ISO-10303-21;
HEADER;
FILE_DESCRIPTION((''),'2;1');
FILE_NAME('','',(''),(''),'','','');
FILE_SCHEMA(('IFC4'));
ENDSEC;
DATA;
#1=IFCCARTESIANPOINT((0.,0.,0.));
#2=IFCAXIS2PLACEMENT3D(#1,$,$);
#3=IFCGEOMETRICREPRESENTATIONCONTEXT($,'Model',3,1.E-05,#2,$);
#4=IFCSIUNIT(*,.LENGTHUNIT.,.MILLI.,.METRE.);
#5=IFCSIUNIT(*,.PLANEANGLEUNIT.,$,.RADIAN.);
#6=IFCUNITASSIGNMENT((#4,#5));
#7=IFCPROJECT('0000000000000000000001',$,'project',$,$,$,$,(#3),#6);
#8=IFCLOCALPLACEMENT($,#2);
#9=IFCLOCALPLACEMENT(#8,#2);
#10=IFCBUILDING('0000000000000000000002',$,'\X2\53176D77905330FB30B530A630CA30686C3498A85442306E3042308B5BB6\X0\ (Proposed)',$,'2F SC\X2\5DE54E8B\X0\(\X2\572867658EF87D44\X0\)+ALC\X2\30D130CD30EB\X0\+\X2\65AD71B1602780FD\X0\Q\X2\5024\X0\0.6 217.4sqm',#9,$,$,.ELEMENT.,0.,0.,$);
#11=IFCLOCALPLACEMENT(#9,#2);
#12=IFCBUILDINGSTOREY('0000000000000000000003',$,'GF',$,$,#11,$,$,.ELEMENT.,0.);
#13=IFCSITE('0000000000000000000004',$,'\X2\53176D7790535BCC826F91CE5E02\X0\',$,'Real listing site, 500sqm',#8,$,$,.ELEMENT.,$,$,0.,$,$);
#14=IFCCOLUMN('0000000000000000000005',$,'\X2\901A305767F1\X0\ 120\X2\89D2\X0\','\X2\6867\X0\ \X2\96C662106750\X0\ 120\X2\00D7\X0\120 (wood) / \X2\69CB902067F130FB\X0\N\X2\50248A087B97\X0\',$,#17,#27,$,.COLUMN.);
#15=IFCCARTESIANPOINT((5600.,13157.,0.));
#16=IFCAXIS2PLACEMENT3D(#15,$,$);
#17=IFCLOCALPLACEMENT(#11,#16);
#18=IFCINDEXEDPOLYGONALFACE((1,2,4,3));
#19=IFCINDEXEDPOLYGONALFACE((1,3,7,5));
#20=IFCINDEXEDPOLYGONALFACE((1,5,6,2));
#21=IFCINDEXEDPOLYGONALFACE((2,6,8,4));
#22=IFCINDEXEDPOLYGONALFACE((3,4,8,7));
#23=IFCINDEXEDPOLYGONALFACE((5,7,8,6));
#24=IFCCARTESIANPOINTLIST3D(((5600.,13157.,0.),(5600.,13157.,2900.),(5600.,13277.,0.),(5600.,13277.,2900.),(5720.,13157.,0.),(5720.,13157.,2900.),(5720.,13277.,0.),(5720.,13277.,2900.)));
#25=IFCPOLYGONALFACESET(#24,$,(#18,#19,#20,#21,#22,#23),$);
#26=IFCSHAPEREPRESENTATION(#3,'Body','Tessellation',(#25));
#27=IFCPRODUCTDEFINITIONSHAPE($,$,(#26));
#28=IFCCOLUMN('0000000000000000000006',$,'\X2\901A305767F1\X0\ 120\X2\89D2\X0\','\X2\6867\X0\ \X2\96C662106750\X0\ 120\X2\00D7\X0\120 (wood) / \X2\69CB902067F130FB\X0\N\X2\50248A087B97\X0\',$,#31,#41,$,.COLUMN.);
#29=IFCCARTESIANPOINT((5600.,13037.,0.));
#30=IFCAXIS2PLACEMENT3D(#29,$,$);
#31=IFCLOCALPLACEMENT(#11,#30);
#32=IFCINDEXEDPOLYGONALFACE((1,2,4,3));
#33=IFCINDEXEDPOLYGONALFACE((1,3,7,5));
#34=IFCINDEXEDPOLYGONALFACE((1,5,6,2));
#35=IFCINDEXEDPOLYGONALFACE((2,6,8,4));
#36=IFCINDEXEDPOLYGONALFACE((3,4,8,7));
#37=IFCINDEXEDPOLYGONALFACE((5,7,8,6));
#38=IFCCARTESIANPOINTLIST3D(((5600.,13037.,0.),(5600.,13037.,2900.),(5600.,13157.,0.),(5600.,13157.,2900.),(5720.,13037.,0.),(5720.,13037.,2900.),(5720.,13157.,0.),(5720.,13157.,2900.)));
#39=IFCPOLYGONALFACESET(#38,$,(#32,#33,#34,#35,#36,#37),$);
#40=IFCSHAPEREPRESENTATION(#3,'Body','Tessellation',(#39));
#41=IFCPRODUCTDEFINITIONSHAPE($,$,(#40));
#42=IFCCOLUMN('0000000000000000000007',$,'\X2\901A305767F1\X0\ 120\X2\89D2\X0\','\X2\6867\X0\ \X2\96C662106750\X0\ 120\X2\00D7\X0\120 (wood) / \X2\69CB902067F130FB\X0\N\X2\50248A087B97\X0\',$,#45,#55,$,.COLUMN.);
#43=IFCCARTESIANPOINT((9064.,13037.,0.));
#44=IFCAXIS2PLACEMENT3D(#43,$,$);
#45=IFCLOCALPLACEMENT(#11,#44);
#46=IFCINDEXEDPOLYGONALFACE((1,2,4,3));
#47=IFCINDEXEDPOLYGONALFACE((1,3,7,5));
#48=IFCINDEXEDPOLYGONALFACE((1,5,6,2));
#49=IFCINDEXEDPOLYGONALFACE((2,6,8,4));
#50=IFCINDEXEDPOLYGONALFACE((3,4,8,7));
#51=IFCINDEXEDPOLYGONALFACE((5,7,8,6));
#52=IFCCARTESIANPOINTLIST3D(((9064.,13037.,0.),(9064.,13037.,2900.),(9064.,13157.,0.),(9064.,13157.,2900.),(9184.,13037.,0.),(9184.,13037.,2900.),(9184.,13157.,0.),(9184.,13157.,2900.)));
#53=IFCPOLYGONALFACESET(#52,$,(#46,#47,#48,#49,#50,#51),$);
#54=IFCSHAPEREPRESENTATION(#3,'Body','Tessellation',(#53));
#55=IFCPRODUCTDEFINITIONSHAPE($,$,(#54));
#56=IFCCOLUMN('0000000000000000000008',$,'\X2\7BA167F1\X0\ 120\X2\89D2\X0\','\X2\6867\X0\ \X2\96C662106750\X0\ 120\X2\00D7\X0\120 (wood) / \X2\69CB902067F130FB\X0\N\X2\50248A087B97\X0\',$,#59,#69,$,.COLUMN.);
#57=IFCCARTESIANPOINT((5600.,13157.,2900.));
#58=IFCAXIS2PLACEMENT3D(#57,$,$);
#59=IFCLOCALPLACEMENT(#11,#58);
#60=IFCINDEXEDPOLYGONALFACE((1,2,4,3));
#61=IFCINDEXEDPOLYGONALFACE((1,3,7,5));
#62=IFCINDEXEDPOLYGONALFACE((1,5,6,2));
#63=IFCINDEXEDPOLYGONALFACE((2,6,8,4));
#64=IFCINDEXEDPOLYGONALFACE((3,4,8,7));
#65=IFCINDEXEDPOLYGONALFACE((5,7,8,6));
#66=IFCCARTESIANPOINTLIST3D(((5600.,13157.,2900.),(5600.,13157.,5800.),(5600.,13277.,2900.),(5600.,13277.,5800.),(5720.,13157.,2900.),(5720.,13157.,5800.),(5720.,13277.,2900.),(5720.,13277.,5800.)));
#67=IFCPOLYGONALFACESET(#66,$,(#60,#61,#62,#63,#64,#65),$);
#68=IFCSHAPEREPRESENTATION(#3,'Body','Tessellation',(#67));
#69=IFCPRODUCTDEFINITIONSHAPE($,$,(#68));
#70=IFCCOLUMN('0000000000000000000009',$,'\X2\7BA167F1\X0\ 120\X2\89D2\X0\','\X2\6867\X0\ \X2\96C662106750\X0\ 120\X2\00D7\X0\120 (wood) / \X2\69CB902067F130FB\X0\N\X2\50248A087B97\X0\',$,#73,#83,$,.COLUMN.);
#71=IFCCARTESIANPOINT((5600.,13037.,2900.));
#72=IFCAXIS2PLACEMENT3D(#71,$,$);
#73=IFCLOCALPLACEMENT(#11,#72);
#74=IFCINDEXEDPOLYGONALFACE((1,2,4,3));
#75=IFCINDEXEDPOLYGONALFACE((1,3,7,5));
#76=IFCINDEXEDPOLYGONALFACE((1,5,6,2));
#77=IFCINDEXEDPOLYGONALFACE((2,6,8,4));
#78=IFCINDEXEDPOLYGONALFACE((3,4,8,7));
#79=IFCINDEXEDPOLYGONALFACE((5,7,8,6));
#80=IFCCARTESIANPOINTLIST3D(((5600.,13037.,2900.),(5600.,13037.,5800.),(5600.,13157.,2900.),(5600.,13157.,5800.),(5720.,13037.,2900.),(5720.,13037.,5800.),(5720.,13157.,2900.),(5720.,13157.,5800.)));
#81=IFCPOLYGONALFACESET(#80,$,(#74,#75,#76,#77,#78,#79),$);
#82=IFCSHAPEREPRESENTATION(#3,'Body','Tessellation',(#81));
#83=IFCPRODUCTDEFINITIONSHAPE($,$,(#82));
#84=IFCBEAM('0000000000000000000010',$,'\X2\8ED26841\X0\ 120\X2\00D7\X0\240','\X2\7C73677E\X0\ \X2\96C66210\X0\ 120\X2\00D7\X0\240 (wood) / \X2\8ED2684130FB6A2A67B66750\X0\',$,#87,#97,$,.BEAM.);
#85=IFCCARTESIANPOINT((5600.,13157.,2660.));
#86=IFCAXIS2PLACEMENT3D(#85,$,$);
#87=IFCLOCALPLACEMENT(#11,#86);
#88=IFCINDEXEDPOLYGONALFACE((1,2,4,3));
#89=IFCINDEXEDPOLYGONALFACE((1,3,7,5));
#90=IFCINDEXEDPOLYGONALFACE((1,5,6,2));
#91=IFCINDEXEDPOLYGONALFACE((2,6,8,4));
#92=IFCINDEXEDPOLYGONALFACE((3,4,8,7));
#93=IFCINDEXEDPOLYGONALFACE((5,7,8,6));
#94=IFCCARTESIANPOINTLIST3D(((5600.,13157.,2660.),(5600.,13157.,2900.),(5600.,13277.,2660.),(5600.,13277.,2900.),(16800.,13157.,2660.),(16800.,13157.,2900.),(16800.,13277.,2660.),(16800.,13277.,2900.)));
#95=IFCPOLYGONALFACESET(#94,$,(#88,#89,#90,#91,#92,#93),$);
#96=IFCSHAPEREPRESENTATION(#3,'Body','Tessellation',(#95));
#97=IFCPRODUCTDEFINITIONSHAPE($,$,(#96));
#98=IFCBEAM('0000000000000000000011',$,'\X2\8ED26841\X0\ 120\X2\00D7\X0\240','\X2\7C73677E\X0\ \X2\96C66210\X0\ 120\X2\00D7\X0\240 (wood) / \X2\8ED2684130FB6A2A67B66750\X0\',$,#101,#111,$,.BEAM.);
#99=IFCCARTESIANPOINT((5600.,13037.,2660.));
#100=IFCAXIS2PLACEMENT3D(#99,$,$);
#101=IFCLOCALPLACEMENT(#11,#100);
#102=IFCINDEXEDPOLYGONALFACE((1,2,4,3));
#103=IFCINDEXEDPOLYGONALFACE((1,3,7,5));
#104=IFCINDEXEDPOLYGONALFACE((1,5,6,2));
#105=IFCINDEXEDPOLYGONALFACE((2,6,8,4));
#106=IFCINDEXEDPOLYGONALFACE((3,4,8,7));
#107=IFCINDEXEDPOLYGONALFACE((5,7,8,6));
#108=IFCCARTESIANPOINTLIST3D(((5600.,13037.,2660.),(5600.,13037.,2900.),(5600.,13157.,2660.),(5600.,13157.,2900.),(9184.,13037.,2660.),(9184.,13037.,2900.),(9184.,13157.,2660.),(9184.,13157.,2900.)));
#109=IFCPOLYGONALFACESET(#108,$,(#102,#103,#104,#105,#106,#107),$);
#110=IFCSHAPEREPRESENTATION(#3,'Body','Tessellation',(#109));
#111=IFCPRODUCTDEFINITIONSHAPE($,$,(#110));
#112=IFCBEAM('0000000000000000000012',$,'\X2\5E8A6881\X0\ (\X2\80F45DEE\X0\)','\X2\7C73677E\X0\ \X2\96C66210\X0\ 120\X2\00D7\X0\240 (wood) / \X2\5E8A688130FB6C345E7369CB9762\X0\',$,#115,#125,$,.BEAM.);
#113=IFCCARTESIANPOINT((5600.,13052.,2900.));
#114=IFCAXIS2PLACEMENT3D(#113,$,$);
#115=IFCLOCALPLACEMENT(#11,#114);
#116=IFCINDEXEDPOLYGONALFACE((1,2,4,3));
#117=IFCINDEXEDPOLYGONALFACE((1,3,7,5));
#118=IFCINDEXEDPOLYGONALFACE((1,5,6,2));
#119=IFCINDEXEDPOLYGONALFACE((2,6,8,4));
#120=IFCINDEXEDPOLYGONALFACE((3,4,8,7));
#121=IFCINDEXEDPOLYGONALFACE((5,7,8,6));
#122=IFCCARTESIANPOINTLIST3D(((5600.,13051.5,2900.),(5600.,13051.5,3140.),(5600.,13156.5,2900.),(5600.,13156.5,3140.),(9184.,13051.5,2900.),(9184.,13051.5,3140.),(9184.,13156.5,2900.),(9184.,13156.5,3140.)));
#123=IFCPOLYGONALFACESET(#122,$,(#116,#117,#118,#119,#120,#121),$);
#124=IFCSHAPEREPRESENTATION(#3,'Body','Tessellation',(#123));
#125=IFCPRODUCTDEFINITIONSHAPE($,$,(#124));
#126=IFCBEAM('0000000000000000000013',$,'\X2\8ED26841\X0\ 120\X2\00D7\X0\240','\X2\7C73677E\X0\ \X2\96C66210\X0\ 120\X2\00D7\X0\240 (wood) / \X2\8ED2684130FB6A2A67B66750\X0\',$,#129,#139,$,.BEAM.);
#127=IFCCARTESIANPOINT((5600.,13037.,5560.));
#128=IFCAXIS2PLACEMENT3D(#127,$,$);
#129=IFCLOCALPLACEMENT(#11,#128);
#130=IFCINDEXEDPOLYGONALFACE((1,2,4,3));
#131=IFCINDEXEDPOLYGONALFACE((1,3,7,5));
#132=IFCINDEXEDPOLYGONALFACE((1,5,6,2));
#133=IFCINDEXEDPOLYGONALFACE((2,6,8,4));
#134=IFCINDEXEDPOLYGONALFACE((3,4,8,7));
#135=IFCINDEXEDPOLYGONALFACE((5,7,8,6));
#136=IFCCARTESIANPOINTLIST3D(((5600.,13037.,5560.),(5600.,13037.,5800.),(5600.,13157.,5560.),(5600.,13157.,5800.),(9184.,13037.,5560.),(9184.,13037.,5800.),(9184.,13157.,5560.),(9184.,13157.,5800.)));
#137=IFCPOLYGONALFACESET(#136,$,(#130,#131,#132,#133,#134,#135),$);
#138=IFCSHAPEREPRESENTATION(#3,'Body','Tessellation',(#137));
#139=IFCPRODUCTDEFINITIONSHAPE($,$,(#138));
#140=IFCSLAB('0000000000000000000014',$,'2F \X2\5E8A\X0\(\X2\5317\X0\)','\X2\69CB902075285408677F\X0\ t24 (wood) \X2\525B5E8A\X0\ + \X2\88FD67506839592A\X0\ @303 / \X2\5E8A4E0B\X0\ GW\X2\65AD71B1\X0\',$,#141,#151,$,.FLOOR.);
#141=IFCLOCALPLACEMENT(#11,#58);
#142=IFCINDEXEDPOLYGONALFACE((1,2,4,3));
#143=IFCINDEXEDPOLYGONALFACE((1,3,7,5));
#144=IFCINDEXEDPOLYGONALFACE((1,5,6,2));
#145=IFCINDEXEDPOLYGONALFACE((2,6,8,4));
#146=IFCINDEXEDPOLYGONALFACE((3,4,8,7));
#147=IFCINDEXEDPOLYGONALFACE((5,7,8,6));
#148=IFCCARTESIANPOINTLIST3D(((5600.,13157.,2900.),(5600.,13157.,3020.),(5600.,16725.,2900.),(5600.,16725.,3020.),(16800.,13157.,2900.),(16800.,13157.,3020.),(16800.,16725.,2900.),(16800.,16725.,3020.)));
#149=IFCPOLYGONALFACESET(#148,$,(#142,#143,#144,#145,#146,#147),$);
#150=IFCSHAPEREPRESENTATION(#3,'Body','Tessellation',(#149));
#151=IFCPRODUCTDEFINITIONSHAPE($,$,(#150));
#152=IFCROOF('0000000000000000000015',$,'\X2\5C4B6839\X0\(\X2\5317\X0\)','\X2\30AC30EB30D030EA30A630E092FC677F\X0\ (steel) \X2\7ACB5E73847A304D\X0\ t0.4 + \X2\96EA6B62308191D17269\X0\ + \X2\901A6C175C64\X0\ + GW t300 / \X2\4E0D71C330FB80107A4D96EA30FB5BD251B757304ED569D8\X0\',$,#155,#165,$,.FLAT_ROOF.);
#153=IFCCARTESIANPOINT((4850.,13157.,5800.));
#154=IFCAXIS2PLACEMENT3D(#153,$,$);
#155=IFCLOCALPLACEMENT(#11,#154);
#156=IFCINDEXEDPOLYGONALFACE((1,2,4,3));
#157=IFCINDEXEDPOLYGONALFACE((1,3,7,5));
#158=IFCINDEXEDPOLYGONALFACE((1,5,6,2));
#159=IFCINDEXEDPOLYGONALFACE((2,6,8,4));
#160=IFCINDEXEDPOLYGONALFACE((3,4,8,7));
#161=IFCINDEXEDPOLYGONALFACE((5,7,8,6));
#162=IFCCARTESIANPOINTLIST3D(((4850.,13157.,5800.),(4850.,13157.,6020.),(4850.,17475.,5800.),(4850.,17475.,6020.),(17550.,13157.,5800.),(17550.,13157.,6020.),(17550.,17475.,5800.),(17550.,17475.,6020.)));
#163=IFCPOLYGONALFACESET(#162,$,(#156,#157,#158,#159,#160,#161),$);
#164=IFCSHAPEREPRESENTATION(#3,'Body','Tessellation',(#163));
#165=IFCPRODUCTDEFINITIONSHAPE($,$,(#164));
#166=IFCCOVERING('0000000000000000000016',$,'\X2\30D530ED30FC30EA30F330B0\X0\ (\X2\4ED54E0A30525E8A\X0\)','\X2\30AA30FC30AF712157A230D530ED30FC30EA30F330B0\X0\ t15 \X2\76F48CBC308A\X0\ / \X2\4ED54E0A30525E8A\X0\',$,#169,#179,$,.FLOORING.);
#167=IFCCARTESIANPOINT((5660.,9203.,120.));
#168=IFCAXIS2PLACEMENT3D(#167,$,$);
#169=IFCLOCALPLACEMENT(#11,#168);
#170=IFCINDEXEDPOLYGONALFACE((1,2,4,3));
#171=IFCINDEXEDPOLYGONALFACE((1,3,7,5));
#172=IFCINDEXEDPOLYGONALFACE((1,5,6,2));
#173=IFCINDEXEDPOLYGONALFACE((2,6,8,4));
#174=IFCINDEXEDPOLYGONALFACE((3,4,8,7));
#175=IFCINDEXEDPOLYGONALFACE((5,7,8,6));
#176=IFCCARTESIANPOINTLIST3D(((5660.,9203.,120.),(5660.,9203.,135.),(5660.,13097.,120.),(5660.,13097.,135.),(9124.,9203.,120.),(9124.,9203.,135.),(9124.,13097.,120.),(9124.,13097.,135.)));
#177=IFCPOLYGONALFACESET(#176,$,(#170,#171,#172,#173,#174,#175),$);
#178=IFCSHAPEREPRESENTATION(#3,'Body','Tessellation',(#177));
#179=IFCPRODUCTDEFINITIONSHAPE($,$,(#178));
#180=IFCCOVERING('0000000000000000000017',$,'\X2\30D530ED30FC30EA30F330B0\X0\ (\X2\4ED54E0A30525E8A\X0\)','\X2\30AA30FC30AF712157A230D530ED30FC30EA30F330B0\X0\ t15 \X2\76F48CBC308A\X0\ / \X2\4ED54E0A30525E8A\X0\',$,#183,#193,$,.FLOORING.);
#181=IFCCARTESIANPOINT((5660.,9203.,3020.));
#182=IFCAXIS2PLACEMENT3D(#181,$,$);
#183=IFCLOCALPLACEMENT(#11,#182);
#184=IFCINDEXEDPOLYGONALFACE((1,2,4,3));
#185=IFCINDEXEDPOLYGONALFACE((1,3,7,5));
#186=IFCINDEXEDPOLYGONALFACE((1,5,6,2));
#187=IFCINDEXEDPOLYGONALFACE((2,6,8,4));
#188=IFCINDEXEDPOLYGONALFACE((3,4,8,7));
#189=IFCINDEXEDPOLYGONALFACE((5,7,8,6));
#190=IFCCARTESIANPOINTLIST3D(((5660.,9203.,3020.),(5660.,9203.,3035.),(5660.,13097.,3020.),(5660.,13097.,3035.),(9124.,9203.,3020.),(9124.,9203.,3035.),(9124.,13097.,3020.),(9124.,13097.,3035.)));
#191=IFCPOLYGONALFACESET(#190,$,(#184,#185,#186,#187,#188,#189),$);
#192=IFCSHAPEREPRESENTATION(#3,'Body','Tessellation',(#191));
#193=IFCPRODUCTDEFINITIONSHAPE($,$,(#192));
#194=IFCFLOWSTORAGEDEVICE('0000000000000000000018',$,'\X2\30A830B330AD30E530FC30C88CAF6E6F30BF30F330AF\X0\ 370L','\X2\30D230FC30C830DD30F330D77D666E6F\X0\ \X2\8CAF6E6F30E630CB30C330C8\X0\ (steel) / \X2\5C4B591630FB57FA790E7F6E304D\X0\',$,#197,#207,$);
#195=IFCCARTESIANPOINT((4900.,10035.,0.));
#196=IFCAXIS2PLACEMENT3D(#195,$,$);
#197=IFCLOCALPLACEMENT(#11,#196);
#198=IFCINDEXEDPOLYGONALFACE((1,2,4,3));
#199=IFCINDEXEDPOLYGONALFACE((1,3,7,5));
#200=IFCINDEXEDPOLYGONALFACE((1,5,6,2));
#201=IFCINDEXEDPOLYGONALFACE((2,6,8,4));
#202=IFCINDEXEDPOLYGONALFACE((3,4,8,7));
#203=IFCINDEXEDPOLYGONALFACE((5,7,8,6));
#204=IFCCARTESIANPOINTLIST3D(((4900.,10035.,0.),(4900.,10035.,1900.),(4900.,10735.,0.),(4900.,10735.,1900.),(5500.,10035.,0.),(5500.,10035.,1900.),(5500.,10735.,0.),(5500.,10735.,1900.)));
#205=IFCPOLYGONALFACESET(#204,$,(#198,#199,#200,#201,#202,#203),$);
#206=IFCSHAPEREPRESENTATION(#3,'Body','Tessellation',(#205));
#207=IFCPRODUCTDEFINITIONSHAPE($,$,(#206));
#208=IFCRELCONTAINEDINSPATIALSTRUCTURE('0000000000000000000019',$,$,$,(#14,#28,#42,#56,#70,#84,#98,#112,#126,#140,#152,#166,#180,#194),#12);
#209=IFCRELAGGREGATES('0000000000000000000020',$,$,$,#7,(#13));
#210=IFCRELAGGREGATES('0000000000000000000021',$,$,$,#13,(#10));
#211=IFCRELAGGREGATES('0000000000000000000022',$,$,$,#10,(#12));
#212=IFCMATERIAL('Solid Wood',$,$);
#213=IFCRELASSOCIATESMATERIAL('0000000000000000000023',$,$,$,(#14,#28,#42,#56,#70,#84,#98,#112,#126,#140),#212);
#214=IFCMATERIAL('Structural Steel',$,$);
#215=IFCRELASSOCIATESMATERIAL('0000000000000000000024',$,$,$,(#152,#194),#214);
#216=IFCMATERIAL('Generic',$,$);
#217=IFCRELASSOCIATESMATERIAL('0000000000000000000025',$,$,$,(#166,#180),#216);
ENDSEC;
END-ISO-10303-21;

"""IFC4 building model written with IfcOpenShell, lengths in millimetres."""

from ifc_helpers import new_model, si_unit, frame, frame_2d, origin, place, context, project, spatial, rectangle, extrude, material, element, save


model = new_model("IFC4")

# Units and contexts
model_context = context("Model", 3, precision=1e-05, world=origin())
ifc_project = project(units=[si_unit("LENGTHUNIT", "METRE", prefix="MILLI"), si_unit("PLANEANGLEUNIT", "RADIAN")], contexts=[model_context])

# Site, building, storey
site_placement = place(None, origin())
site = spatial("IfcSite", under=ifc_project, at=site_placement, Name="北海道富良野市", ObjectType="Real listing site, 500sqm", CompositionType="ELEMENT", RefElevation=0.0)
building_placement = place(site_placement, origin())
building = spatial("IfcBuilding", under=site, at=building_placement, Name="北海道・サウナと水風呂のある家 (Proposed)", ObjectType="2F SC工事(在来軸組)+ALCパネル+断熱性能Q値0.6 217.4sqm", CompositionType="ELEMENT", ElevationOfRefHeight=0.0, ElevationOfTerrain=0.0)
storey_placement = place(building_placement, origin())
storey = spatial("IfcBuildingStorey", under=building, at=storey_placement, Name="GF", CompositionType="ELEMENT", Elevation=0.0)

# Columns
ifc_material_1 = material(Name="Solid Wood")
column_1_placement = place(storey_placement, frame((5600.0, 13157.0, 0.0)))
element("IfcColumn", 1, at=column_1_placement, inside=storey, material=ifc_material_1, Name="通し柱 120角", Description="桧 集成材 120×120 (wood) / 構造柱・N値計算", PredefinedType="COLUMN", context=model_context, shape_type="SweptSolid", body=[
    extrude(rectangle(XDim=120.0, YDim=120.0, at=frame_2d((60.0, 60.0))), frame((5600.0, 13157.0, 0.0)), (0.0, 0.0, 1.0), 2900.0),
])
column_2_placement = place(storey_placement, frame((5600.0, 13037.0, 0.0)))
element("IfcColumn", 2, at=column_2_placement, inside=storey, material=ifc_material_1, Name="通し柱 120角", Description="桧 集成材 120×120 (wood) / 構造柱・N値計算", PredefinedType="COLUMN", context=model_context, shape_type="SweptSolid", body=[
    extrude(rectangle(XDim=120.0, YDim=120.0, at=frame_2d((60.0, 60.0))), frame((5600.0, 13037.0, 0.0)), (0.0, 0.0, 1.0), 2900.0),
])
column_3_placement = place(storey_placement, frame((9064.0, 13037.0, 0.0)))
element("IfcColumn", 3, at=column_3_placement, inside=storey, material=ifc_material_1, Name="通し柱 120角", Description="桧 集成材 120×120 (wood) / 構造柱・N値計算", PredefinedType="COLUMN", context=model_context, shape_type="SweptSolid", body=[
    extrude(rectangle(XDim=120.0, YDim=120.0, at=frame_2d((60.0, 60.0))), frame((9064.0, 13037.0, 0.0)), (0.0, 0.0, 1.0), 2900.0),
])
column_4_placement = place(storey_placement, frame((5600.0, 13157.0, 2900.0)))
element("IfcColumn", 4, at=column_4_placement, inside=storey, material=ifc_material_1, Name="管柱 120角", Description="桧 集成材 120×120 (wood) / 構造柱・N値計算", PredefinedType="COLUMN", context=model_context, shape_type="SweptSolid", body=[
    extrude(rectangle(XDim=120.0, YDim=120.0, at=frame_2d((60.0, 60.0))), frame((5600.0, 13157.0, 2900.0)), (0.0, 0.0, 1.0), 2900.0),
])
column_5_placement = place(storey_placement, frame((5600.0, 13037.0, 2900.0)))
element("IfcColumn", 5, at=column_5_placement, inside=storey, material=ifc_material_1, Name="管柱 120角", Description="桧 集成材 120×120 (wood) / 構造柱・N値計算", PredefinedType="COLUMN", context=model_context, shape_type="SweptSolid", body=[
    extrude(rectangle(XDim=120.0, YDim=120.0, at=frame_2d((60.0, 60.0))), frame((5600.0, 13037.0, 2900.0)), (0.0, 0.0, 1.0), 2900.0),
])

# Beams
beam_1_placement = place(storey_placement, frame((5600.0, 13157.0, 2660.0)))
element("IfcBeam", 6, at=beam_1_placement, inside=storey, material=ifc_material_1, Name="軒桁 120×240", Description="米松 集成 120×240 (wood) / 軒桁・横架材", PredefinedType="BEAM", context=model_context, shape_type="SweptSolid", body=[
    extrude(rectangle(XDim=11200.0, YDim=120.0, at=frame_2d((5600.0, 60.0))), frame((5600.0, 13157.0, 2660.0)), (0.0, 0.0, 1.0), 240.0),
])
beam_2_placement = place(storey_placement, frame((5600.0, 13037.0, 2660.0)))
element("IfcBeam", 7, at=beam_2_placement, inside=storey, material=ifc_material_1, Name="軒桁 120×240", Description="米松 集成 120×240 (wood) / 軒桁・横架材", PredefinedType="BEAM", context=model_context, shape_type="SweptSolid", body=[
    extrude(rectangle(XDim=3584.0, YDim=120.0, at=frame_2d((1792.0, 60.0))), frame((5600.0, 13037.0, 2660.0)), (0.0, 0.0, 1.0), 240.0),
])
beam_3_placement = place(storey_placement, frame((5600.0, 13052.0, 2900.0)))
element("IfcBeam", 8, at=beam_3_placement, inside=storey, material=ifc_material_1, Name="床梁 (胴差)", Description="米松 集成 120×240 (wood) / 床梁・水平構面", PredefinedType="BEAM", context=model_context, shape_type="SweptSolid", body=[
    extrude(rectangle(XDim=3584.0, YDim=105.0, at=frame_2d((1792.0, 52.0))), frame((5600.0, 13052.0, 2900.0)), (0.0, 0.0, 1.0), 240.0),
])
beam_4_placement = place(storey_placement, frame((5600.0, 13037.0, 5560.0)))
element("IfcBeam", 9, at=beam_4_placement, inside=storey, material=ifc_material_1, Name="軒桁 120×240", Description="米松 集成 120×240 (wood) / 軒桁・横架材", PredefinedType="BEAM", context=model_context, shape_type="SweptSolid", body=[
    extrude(rectangle(XDim=3584.0, YDim=120.0, at=frame_2d((1792.0, 60.0))), frame((5600.0, 13037.0, 5560.0)), (0.0, 0.0, 1.0), 240.0),
])

# Slab
slab_1_placement = place(storey_placement, frame((5600.0, 13157.0, 2900.0)))
element("IfcSlab", 10, at=slab_1_placement, inside=storey, material=ifc_material_1, Name="2F 床(北)", Description="構造用合板 t24 (wood) 剛床 + 製材根太 @303 / 床下 GW断熱", PredefinedType="FLOOR", context=model_context, shape_type="SweptSolid", body=[
    extrude(rectangle(XDim=11200.0, YDim=3568.0, at=frame_2d((5600.0, 1784.0))), frame((5600.0, 13157.0, 2900.0)), (0.0, 0.0, 1.0), 120.0),
])

# Roof
ifc_material_2 = material(Name="Structural Steel")
for number, where, name in (
    (11, (4850.0, 13157.0, 5800.0), "屋根(北)"),
):
    element("IfcRoof", number, at=place(storey_placement, frame(where)), inside=storey, material=ifc_material_2, Name=name, Description="ガルバリウム鋼板 (steel) 立平葺き t0.4 + 雪止め金物 + 通気層 + GW t300 / 不燃・耐積雪・寒冷地仕様", PredefinedType="FLAT_ROOF", context=model_context, shape_type="SweptSolid", body=[
        extrude(rectangle(XDim=12700.0, YDim=4318.0, at=frame_2d((6350.0, 2159.0))), frame((4850.0, 13157.0, 5800.0)), (0.0, 0.0, 1.0), 220.0),
    ])

# Coverings
ifc_material_3 = material(Name="Generic")
covering_1_placement = place(storey_placement, frame((5660.0, 9203.0, 120.0)))
element("IfcCovering", 12, at=covering_1_placement, inside=storey, material=ifc_material_3, Name="フローリング (仕上げ床)", Description="オーク無垢フローリング t15 直貼り / 仕上げ床", PredefinedType="FLOORING", context=model_context, shape_type="SweptSolid", body=[
    extrude(rectangle(XDim=3464.0, YDim=3894.0, at=frame_2d((1732.0, 1947.0))), frame((5660.0, 9203.0, 120.0)), (0.0, 0.0, 1.0), 15.0),
])
covering_2_placement = place(storey_placement, frame((5660.0, 9203.0, 3020.0)))
element("IfcCovering", 13, at=covering_2_placement, inside=storey, material=ifc_material_3, Name="フローリング (仕上げ床)", Description="オーク無垢フローリング t15 直貼り / 仕上げ床", PredefinedType="FLOORING", context=model_context, shape_type="SweptSolid", body=[
    extrude(rectangle(XDim=3464.0, YDim=3894.0, at=frame_2d((1732.0, 1947.0))), frame((5660.0, 9203.0, 3020.0)), (0.0, 0.0, 1.0), 15.0),
])

# Flow storage device
flow_storage_device_placement = place(storey_placement, frame((4900.0, 10035.0, 0.0)))
element("IfcFlowStorageDevice", 14, at=flow_storage_device_placement, inside=storey, material=ifc_material_2, Name="エコキュート貯湯タンク 370L", Description="ヒートポンプ給湯 貯湯ユニット (steel) / 屋外・基礎置き", context=model_context, shape_type="SweptSolid", body=[
    extrude(rectangle(XDim=600.0, YDim=700.0, at=frame_2d((300.0, 350.0))), frame((4900.0, 10035.0, 0.0)), (0.0, 0.0, 1.0), 1900.0),
])

save(model, "model.ifc")
